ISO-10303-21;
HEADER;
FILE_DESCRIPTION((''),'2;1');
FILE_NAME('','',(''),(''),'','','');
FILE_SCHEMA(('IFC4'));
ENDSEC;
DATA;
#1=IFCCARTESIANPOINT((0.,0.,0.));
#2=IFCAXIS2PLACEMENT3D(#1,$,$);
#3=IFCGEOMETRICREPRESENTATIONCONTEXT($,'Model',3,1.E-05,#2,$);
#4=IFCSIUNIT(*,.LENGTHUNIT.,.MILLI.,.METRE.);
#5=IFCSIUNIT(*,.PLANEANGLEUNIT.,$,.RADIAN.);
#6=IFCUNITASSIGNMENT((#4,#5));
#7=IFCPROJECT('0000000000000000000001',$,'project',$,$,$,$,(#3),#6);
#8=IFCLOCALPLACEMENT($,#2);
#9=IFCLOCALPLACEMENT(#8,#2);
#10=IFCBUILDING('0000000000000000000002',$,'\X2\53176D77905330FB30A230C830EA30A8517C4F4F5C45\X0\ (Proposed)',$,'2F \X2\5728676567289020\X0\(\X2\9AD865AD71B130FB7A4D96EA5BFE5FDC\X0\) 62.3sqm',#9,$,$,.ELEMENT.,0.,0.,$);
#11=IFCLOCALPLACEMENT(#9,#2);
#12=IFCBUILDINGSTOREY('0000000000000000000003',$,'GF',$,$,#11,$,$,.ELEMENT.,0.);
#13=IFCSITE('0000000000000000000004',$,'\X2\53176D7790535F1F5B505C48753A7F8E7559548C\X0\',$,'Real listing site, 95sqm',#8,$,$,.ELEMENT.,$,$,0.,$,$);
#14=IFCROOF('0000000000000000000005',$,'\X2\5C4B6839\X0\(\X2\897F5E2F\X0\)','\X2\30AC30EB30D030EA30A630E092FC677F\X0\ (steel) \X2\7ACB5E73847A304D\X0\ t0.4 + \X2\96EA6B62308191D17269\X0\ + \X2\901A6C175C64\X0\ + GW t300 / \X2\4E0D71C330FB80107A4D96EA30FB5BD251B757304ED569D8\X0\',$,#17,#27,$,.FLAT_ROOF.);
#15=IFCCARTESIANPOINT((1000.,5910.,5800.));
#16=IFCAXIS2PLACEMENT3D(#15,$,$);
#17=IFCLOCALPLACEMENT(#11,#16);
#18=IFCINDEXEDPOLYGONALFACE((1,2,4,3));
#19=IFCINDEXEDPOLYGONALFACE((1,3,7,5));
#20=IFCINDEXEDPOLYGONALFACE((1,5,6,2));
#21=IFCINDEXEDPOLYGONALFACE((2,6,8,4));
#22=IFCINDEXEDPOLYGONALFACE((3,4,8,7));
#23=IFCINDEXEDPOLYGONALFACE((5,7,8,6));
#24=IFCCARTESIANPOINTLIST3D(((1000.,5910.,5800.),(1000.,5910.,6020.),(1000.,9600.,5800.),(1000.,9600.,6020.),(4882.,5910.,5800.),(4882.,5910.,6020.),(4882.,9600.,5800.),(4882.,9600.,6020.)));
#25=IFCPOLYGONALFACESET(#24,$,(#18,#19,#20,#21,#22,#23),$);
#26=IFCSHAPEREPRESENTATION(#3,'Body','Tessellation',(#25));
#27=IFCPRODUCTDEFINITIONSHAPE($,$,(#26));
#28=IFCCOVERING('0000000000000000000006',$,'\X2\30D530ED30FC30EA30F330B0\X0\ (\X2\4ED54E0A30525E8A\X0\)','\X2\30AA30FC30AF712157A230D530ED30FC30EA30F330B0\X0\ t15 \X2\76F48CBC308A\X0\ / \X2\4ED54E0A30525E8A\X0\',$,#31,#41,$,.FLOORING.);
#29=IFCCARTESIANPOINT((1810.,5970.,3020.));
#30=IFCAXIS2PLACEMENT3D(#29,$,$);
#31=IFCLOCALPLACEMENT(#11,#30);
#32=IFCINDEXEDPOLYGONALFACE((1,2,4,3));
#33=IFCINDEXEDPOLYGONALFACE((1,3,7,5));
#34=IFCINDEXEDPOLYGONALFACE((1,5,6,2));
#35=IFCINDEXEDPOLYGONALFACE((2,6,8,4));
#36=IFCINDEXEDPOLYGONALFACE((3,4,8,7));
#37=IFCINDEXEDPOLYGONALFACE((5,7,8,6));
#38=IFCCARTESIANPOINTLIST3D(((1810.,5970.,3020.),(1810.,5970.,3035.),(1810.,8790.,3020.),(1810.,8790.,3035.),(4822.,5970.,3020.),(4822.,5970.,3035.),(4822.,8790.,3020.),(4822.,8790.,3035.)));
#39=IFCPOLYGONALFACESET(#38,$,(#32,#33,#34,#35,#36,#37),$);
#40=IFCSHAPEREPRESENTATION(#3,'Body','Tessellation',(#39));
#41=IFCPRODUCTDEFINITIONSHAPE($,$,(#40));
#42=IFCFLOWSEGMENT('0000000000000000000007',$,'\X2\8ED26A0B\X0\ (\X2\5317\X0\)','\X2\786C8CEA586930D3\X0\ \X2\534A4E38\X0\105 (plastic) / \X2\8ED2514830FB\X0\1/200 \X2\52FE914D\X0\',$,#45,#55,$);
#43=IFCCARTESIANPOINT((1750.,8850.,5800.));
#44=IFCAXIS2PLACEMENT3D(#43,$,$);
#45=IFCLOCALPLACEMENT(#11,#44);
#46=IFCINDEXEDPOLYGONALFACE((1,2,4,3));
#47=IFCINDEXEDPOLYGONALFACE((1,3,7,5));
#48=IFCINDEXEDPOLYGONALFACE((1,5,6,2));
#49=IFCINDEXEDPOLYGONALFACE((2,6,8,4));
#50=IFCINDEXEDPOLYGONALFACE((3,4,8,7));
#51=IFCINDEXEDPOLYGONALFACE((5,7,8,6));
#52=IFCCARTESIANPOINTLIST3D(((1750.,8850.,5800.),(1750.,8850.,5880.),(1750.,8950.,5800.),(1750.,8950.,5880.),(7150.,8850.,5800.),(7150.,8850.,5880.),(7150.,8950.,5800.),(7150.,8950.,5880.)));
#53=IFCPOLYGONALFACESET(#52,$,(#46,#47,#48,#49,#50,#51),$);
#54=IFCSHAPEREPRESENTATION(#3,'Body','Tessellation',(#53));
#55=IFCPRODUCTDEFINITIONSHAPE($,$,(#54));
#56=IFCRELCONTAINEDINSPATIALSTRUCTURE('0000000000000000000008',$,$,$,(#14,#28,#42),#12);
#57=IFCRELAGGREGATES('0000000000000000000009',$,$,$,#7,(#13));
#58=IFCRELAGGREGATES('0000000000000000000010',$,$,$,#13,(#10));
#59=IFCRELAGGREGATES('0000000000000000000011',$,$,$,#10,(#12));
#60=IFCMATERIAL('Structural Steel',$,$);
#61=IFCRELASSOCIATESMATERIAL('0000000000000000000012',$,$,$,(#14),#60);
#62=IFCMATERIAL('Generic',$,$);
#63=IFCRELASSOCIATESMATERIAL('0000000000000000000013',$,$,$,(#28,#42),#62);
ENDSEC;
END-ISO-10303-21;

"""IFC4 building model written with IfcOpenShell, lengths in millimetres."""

from ifc_helpers import new_model, si_unit, frame, frame_2d, origin, place, context, project, spatial, rectangle, extrude, material, element, save


model = new_model("IFC4")

# Units and contexts
model_context = context("Model", 3, precision=1e-05, world=origin())
ifc_project = project(units=[si_unit("LENGTHUNIT", "METRE", prefix="MILLI"), si_unit("PLANEANGLEUNIT", "RADIAN")], contexts=[model_context])

# Site, building, storey
site_placement = place(None, origin())
site = spatial("IfcSite", under=ifc_project, at=site_placement, Name="北海道弟子屈町美留和", ObjectType="Real listing site, 95sqm", CompositionType="ELEMENT", RefElevation=0.0)
building_placement = place(site_placement, origin())
building = spatial("IfcBuilding", under=site, at=building_placement, Name="北海道・アトリエ兼住居 (Proposed)", ObjectType="2F 在来木造(高断熱・積雪対応) 62.3sqm", CompositionType="ELEMENT", ElevationOfRefHeight=0.0, ElevationOfTerrain=0.0)
storey_placement = place(building_placement, origin())
storey = spatial("IfcBuildingStorey", under=building, at=storey_placement, Name="GF", CompositionType="ELEMENT", Elevation=0.0)

# Roof
ifc_material_1 = material(Name="Structural Steel")
for number, where, name in (
    (1, (1000.0, 5910.0, 5800.0), "屋根(西帯)"),
):
    element("IfcRoof", number, at=place(storey_placement, frame(where)), inside=storey, material=ifc_material_1, Name=name, Description="ガルバリウム鋼板 (steel) 立平葺き t0.4 + 雪止め金物 + 通気層 + GW t300 / 不燃・耐積雪・寒冷地仕様", PredefinedType="FLAT_ROOF", context=model_context, shape_type="SweptSolid", body=[
        extrude(rectangle(XDim=3882.0, YDim=3690.0, at=frame_2d((1941.0, 1845.0))), frame((1000.0, 5910.0, 5800.0)), (0.0, 0.0, 1.0), 220.0),
    ])

# Covering
ifc_material_2 = material(Name="Generic")
covering_placement = place(storey_placement, frame((1810.0, 5970.0, 3020.0)))
element("IfcCovering", 2, at=covering_placement, inside=storey, material=ifc_material_2, Name="フローリング (仕上げ床)", Description="オーク無垢フローリング t15 直貼り / 仕上げ床", PredefinedType="FLOORING", context=model_context, shape_type="SweptSolid", body=[
    extrude(rectangle(XDim=3012.0, YDim=2820.0, at=frame_2d((1506.0, 1410.0))), frame((1810.0, 5970.0, 3020.0)), (0.0, 0.0, 1.0), 15.0),
])

# Flow segment
flow_segment_placement = place(storey_placement, frame((1750.0, 8850.0, 5800.0)))
element("IfcFlowSegment", 3, at=flow_segment_placement, inside=storey, material=ifc_material_2, Name="軒樋 (北)", Description="硬質塩ビ 半丸105 (plastic) / 軒先・1/200 勾配", context=model_context, shape_type="SweptSolid", body=[
    extrude(rectangle(XDim=5400.0, YDim=100.0, at=frame_2d((2700.0, 50.0))), frame((1750.0, 8850.0, 5800.0)), (0.0, 0.0, 1.0), 80.0),
])

save(model, "model.ifc")
